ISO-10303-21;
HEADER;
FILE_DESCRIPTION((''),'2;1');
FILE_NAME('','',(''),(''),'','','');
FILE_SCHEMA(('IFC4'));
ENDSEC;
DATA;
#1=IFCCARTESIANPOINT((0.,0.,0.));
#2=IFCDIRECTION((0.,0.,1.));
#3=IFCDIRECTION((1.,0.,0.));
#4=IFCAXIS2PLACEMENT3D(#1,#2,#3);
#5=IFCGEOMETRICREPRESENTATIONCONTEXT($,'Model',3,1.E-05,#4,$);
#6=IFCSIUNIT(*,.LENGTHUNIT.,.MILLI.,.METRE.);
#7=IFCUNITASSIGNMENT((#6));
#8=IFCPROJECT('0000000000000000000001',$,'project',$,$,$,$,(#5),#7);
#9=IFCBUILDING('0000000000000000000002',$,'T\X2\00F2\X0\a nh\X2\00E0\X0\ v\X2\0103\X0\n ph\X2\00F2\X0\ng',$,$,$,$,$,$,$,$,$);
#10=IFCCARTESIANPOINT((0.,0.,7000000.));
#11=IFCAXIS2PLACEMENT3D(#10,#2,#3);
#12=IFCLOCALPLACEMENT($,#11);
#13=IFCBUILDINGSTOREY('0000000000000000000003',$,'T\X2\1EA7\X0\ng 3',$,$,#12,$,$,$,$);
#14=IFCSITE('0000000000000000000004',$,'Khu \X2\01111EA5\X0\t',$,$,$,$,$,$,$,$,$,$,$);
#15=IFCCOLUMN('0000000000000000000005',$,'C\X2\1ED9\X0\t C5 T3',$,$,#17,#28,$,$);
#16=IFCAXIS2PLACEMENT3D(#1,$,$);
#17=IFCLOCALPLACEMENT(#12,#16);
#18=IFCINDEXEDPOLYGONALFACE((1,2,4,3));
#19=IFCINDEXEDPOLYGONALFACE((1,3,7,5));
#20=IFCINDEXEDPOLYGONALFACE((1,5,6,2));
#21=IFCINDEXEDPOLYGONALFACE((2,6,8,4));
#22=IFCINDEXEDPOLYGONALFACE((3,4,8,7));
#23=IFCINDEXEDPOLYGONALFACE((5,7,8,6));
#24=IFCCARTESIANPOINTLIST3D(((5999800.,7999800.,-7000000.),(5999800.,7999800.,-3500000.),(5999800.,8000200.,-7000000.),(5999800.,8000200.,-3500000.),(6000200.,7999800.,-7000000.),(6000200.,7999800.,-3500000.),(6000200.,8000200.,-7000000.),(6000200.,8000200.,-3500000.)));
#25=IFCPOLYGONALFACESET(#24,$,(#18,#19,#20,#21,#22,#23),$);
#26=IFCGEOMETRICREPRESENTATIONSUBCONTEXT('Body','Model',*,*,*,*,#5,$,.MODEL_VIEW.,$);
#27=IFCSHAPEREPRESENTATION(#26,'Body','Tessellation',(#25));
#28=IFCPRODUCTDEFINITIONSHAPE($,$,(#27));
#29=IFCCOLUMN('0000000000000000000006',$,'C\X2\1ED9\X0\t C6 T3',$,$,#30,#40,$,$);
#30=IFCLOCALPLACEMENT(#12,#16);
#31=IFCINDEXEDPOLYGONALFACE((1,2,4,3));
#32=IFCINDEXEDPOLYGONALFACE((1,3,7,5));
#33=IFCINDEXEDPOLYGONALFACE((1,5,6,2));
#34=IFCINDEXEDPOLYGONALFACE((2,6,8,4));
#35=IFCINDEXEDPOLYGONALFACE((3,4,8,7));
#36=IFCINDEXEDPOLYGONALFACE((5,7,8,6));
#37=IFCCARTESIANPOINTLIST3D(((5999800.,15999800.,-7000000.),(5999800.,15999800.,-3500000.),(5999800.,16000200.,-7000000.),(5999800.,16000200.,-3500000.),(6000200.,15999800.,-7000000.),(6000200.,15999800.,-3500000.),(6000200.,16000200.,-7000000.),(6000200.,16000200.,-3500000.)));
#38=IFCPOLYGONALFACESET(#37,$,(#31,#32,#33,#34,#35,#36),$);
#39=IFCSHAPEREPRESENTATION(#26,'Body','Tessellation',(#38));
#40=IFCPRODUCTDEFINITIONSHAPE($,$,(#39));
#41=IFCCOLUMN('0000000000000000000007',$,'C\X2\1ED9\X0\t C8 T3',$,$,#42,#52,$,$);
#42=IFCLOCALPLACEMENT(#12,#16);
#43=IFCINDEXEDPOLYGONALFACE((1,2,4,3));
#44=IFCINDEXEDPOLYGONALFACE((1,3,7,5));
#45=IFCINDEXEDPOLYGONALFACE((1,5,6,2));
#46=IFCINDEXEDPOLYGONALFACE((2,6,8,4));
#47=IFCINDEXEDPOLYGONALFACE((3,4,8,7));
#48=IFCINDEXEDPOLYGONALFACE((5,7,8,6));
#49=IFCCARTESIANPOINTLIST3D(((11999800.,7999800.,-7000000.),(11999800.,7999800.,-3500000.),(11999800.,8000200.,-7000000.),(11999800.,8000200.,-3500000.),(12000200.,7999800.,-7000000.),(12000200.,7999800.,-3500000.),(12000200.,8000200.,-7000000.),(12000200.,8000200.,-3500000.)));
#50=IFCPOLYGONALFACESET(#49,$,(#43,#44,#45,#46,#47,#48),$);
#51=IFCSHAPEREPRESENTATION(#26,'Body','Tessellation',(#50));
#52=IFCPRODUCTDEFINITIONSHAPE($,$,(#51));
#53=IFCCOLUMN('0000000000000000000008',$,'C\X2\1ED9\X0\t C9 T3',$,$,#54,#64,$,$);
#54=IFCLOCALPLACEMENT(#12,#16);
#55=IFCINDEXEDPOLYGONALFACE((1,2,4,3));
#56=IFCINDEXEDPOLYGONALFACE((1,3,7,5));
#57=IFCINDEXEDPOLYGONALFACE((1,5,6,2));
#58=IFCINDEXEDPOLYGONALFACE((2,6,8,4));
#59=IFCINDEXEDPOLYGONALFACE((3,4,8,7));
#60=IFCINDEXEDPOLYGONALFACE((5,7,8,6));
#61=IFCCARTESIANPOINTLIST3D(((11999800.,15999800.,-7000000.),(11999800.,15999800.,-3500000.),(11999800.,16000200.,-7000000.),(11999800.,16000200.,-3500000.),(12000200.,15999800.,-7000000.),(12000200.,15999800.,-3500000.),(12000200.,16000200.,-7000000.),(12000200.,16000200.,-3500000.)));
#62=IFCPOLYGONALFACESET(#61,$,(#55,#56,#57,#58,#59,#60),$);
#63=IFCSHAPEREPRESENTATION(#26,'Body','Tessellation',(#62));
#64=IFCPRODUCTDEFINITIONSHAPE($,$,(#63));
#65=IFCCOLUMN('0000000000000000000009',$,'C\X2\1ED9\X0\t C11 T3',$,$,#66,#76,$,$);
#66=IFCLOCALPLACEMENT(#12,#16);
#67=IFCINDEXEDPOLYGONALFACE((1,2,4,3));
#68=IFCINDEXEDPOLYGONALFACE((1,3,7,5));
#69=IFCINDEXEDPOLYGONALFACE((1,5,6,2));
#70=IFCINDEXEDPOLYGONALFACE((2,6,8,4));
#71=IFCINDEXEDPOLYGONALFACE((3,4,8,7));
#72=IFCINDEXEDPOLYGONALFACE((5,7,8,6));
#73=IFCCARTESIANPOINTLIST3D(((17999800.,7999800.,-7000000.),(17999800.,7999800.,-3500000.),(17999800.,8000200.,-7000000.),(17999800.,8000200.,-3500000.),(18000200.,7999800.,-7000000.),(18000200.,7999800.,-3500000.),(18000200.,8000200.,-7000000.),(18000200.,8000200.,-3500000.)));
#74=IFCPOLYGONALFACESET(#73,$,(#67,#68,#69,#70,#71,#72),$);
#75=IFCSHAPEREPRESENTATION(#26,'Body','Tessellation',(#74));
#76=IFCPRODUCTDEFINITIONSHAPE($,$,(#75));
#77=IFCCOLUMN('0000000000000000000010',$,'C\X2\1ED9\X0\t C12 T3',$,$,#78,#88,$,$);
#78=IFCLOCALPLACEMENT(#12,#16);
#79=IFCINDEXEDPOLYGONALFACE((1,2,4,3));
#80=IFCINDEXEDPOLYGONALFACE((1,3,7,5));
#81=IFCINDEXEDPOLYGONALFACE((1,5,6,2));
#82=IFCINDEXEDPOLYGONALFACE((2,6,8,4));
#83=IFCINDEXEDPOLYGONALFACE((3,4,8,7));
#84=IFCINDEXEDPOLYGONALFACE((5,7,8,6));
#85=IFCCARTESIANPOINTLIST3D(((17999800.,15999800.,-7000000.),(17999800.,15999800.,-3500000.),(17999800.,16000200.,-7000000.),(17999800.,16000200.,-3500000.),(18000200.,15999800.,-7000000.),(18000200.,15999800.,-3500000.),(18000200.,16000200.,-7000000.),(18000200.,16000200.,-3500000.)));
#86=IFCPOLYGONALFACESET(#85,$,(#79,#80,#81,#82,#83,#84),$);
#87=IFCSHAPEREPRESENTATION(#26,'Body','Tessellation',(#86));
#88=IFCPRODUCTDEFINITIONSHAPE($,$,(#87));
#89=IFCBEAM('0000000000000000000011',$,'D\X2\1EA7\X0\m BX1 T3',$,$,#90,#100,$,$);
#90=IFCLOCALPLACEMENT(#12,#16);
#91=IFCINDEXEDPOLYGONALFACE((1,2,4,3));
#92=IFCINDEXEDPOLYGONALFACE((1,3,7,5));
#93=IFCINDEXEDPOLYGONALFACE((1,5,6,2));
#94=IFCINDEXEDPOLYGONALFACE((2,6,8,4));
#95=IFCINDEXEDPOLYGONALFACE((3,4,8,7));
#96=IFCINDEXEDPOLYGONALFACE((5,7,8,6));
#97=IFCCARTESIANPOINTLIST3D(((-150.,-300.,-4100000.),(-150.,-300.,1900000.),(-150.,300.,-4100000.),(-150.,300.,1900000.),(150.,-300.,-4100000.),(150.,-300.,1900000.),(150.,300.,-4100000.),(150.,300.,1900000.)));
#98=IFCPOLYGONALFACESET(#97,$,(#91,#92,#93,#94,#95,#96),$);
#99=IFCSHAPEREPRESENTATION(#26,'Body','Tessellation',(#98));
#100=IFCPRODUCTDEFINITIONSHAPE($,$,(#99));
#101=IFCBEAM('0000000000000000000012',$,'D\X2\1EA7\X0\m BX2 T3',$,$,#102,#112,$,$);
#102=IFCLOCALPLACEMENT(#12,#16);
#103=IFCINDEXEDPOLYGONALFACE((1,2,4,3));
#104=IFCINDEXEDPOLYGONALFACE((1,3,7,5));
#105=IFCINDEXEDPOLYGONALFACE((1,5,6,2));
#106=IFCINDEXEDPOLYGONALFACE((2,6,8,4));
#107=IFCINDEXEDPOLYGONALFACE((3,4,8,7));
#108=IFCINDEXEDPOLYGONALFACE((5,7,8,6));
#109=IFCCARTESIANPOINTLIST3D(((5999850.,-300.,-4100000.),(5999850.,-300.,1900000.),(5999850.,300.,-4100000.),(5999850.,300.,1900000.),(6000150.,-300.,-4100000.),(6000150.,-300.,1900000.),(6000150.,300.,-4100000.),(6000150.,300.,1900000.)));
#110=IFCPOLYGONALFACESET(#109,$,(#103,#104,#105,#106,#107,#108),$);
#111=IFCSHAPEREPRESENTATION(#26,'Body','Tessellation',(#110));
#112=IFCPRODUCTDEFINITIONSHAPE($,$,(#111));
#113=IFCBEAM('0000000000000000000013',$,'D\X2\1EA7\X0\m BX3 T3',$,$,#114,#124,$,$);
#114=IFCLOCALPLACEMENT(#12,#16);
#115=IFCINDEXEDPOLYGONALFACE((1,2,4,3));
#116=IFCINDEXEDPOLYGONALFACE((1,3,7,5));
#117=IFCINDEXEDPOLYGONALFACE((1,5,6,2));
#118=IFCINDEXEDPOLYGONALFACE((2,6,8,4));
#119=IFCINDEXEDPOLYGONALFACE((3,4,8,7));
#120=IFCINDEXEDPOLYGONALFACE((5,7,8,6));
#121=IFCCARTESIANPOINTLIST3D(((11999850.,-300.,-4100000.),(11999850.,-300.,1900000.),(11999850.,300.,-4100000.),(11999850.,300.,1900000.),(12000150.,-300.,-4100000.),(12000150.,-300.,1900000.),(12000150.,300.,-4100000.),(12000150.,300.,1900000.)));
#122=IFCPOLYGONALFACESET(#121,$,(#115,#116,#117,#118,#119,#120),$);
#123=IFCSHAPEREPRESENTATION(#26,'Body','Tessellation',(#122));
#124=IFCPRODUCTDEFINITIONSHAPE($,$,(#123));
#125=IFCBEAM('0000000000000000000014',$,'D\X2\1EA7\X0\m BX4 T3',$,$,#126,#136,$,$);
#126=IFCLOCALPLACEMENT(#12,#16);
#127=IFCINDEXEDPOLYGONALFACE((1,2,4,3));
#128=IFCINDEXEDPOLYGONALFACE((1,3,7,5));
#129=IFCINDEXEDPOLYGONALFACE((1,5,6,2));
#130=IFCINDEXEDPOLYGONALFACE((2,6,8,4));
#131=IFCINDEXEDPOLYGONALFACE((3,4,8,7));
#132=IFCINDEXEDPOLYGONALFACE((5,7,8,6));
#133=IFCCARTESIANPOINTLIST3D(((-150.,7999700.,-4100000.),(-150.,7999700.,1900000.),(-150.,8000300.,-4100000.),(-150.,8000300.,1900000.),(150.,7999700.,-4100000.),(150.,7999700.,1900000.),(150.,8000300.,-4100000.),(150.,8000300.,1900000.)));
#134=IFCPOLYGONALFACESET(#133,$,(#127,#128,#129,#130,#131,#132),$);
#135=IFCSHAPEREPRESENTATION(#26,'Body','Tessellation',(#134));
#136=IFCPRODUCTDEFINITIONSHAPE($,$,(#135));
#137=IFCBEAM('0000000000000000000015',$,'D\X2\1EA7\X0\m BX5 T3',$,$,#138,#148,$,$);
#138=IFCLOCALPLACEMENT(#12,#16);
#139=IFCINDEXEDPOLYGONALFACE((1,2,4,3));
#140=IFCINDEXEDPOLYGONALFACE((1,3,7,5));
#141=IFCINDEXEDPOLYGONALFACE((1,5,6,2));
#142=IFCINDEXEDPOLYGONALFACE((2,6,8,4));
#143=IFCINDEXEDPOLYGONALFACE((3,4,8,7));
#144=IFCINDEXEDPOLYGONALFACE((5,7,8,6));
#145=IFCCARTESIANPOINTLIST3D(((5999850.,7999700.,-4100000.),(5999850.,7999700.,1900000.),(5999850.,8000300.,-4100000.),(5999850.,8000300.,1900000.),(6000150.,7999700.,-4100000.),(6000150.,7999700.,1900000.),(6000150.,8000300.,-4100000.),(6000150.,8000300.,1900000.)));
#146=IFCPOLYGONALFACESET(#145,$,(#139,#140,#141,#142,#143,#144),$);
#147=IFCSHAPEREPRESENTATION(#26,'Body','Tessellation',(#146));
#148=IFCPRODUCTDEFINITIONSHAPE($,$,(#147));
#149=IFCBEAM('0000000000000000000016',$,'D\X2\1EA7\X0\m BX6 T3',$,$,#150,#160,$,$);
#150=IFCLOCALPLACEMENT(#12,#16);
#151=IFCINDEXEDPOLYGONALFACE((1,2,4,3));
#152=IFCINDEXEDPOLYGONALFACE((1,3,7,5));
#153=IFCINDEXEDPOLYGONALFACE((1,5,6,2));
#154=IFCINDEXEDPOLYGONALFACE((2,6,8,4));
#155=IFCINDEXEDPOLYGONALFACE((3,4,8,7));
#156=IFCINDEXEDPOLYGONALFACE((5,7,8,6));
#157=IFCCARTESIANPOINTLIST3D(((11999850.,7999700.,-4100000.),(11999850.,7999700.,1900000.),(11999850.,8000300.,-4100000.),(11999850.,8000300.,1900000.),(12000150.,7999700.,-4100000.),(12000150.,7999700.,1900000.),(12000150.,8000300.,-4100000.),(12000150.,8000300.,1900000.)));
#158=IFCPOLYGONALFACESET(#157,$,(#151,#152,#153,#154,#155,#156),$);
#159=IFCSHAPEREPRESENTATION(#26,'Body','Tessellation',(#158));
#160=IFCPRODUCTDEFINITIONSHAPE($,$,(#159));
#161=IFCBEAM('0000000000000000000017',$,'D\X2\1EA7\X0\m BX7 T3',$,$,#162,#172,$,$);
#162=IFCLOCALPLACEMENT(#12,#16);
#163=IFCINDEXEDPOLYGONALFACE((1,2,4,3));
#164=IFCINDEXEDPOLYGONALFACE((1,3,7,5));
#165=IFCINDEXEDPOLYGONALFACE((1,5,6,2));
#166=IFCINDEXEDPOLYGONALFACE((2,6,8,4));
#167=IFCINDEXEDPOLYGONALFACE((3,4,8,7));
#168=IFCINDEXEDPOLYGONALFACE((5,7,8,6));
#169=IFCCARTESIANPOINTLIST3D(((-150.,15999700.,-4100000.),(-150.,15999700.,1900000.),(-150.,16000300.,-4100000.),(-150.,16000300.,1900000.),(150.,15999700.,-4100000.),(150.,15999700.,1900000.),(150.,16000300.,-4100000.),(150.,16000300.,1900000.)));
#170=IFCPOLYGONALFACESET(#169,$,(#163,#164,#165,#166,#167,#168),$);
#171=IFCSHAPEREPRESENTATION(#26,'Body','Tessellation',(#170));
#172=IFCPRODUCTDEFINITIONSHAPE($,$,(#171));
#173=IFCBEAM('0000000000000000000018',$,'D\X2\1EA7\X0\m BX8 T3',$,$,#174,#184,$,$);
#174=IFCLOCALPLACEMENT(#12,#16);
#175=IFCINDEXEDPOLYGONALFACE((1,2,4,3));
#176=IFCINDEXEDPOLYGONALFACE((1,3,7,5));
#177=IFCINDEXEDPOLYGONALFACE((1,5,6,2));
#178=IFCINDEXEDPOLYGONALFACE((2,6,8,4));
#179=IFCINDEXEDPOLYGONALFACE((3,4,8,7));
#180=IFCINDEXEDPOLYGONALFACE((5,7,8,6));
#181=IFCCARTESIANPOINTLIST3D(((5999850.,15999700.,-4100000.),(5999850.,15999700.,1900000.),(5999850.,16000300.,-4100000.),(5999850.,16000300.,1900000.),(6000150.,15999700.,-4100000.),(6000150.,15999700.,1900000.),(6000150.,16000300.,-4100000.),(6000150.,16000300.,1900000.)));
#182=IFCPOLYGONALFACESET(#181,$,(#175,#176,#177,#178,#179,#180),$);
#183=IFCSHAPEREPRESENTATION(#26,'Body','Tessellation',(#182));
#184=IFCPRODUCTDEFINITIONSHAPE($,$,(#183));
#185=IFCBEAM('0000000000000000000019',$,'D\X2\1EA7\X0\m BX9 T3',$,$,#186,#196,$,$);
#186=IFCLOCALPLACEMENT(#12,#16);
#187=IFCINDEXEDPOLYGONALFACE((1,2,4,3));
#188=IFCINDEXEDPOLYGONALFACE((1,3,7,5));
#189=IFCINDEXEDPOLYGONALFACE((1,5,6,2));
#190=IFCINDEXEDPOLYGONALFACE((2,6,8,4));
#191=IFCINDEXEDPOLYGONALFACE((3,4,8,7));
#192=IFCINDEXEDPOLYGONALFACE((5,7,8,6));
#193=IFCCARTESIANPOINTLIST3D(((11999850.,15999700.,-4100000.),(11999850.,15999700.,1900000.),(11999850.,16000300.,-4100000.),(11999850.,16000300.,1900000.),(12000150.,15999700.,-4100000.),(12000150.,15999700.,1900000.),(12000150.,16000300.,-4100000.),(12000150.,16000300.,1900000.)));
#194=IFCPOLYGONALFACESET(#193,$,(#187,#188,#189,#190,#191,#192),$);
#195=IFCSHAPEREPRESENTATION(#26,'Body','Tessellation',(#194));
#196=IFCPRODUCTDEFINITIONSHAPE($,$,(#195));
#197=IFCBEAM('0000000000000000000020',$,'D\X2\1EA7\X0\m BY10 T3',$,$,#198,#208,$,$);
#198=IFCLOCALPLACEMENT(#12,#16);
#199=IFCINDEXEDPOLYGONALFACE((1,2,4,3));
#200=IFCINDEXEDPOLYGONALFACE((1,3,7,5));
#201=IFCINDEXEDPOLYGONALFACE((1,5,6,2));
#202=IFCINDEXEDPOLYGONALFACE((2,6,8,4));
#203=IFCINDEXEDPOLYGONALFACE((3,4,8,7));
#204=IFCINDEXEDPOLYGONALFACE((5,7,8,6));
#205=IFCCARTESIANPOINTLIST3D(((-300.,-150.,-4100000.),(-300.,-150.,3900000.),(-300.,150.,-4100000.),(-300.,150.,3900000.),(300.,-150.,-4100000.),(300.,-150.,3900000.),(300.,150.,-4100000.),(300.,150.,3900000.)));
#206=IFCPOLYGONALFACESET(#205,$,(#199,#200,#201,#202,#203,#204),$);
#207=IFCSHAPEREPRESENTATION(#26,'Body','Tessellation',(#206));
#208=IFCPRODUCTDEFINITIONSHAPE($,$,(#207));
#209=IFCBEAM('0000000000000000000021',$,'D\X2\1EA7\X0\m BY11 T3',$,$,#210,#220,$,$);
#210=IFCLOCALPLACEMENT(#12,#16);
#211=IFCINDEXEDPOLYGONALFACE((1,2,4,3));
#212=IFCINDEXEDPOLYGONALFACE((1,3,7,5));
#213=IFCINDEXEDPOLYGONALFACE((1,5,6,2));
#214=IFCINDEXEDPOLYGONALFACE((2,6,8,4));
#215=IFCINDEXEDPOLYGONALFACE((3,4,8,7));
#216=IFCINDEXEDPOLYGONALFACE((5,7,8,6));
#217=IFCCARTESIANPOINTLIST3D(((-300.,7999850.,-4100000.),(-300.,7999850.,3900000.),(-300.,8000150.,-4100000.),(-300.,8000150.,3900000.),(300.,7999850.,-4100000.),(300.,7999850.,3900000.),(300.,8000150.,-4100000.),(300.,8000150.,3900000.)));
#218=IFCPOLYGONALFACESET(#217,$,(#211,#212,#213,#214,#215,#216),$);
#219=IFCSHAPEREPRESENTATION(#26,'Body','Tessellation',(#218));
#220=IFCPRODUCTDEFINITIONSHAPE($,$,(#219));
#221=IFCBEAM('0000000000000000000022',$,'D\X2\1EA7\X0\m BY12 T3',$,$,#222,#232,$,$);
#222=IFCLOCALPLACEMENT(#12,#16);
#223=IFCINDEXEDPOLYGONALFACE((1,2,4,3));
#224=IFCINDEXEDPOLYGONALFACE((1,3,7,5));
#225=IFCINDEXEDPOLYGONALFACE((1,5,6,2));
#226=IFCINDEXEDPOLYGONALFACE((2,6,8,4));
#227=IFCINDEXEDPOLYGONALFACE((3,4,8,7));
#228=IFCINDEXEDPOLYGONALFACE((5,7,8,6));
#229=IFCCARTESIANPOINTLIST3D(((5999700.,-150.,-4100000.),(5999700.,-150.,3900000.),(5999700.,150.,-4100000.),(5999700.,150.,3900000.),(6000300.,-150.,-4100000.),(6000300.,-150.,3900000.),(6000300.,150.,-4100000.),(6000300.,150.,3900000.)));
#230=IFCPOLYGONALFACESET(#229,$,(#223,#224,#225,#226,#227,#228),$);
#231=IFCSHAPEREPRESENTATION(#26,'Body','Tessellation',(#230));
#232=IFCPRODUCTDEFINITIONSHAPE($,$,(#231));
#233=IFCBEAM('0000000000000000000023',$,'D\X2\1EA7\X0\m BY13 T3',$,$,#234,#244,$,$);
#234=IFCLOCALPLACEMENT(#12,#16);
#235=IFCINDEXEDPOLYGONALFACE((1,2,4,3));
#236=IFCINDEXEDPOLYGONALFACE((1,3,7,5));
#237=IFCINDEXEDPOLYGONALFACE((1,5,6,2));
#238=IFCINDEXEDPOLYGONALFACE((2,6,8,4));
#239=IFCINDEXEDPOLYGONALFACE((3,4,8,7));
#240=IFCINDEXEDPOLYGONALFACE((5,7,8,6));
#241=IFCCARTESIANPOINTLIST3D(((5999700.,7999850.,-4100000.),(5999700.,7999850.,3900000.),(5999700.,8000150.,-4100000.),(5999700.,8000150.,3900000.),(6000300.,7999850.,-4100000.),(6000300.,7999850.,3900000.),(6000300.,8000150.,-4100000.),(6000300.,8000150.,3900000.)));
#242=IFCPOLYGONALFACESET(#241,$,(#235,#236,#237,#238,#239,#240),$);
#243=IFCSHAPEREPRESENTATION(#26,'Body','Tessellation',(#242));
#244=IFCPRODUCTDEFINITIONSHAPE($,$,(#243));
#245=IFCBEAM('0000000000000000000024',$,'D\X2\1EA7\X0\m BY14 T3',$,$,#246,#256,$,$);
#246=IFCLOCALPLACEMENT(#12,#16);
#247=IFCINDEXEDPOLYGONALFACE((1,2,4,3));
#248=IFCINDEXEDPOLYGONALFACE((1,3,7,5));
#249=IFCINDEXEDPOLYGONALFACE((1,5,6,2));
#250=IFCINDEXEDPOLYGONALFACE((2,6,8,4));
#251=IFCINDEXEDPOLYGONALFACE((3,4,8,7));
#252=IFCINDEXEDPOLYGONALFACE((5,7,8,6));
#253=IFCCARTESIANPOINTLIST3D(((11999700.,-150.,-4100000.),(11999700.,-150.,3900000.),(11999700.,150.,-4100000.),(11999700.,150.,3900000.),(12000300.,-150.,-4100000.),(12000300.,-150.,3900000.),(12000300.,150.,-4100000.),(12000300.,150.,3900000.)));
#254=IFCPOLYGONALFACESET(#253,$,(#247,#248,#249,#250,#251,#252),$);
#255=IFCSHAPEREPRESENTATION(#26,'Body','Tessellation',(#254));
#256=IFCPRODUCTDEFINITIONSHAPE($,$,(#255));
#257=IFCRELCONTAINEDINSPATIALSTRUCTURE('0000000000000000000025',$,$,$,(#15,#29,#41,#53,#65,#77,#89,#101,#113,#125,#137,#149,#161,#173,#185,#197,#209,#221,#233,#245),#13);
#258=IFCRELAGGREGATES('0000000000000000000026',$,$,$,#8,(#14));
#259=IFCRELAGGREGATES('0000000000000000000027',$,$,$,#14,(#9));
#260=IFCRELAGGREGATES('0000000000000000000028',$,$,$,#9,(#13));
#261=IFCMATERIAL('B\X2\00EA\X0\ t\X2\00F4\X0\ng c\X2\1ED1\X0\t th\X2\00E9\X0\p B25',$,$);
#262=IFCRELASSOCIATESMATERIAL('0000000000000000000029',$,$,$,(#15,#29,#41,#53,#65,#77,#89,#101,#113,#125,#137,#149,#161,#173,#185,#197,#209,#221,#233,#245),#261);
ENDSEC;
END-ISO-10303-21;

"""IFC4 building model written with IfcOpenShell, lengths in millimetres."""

from ifc_helpers import new_model, entity, si_unit, frame, origin_with_axes, place, context, subcontext, project, spatial, extrude, material, element, save


model = new_model("IFC4")

# Units and contexts
model_context = context("Model", 3, precision=1e-05, world=origin_with_axes())
body_context = subcontext(model_context, "Body", "Model", "MODEL_VIEW")
ifc_project = project(units=[si_unit("LENGTHUNIT", "METRE", prefix="MILLI")], contexts=[model_context])

# Site, building, storey
site = spatial("IfcSite", under=ifc_project, Name="Khu đất")
building = spatial("IfcBuilding", under=site, Name="Tòa nhà văn phòng")
storey_placement = place(None, frame((0.0, 0.0, 7000000.0), z_axis=(0.0, 0.0, 1.0), x_axis=(1.0, 0.0, 0.0)))
storey = spatial("IfcBuildingStorey", under=building, at=storey_placement, Name="Tầng 3")

# Columns
ifc_material_1 = material(Name="Bê tông cốt thép B25")
for number, where, z_axis, x_axis, name in (
    (1, (6000000.0, 8000000.0, -7000000.0), (0.0, 0.0, 1.0), (1.0, 0.0, 0.0), "Cột C5 T3"),
    (2, (6000000.0, 16000000.0, -7000000.0), (0.0, 0.0, 1.0), (1.0, 0.0, 0.0), "Cột C6 T3"),
    (3, (12000000.0, 8000000.0, -7000000.0), (0.0, 0.0, 1.0), (1.0, 0.0, 0.0), "Cột C8 T3"),
    (4, (12000000.0, 16000000.0, -7000000.0), (0.0, 0.0, 1.0), (1.0, 0.0, 0.0), "Cột C9 T3"),
    (5, (18000000.0, 8000000.0, -7000000.0), (0.0, 0.0, 1.0), (1.0, 0.0, 0.0), "Cột C11 T3"),
    (6, (18000000.0, 16000000.0, -7000000.0), (0.0, 0.0, 1.0), (1.0, 0.0, 0.0), "Cột C12 T3"),
):
    element("IfcColumn", number, at=place(storey_placement, frame(where, z_axis=z_axis, x_axis=x_axis)), inside=storey, material=ifc_material_1, Name=name, context=body_context, shape_type="SweptSolid", body=[
        extrude(entity("IfcRectangleProfileDef", None, None, None, 400.0, 400.0), origin_with_axes(), (0.0, 0.0, 1.0), 3500000.0),
    ])

# Beams
for number, where, z_axis, x_axis, name in (
    (7, (0.0, 0.0, -4100000.0), (0.0, 0.0, 1.0), (1.0, 0.0, 0.0), "Dầm BX1 T3"),
    (8, (6000000.0, 0.0, -4100000.0), (0.0, 0.0, 1.0), (1.0, 0.0, 0.0), "Dầm BX2 T3"),
    (9, (12000000.0, 0.0, -4100000.0), (0.0, 0.0, 1.0), (1.0, 0.0, 0.0), "Dầm BX3 T3"),
    (10, (0.0, 8000000.0, -4100000.0), (0.0, 0.0, 1.0), (1.0, 0.0, 0.0), "Dầm BX4 T3"),
    (11, (6000000.0, 8000000.0, -4100000.0), (0.0, 0.0, 1.0), (1.0, 0.0, 0.0), "Dầm BX5 T3"),
    (12, (12000000.0, 8000000.0, -4100000.0), (0.0, 0.0, 1.0), (1.0, 0.0, 0.0), "Dầm BX6 T3"),
    (13, (0.0, 16000000.0, -4100000.0), (0.0, 0.0, 1.0), (1.0, 0.0, 0.0), "Dầm BX7 T3"),
    (14, (6000000.0, 16000000.0, -4100000.0), (0.0, 0.0, 1.0), (1.0, 0.0, 0.0), "Dầm BX8 T3"),
    (15, (12000000.0, 16000000.0, -4100000.0), (0.0, 0.0, 1.0), (1.0, 0.0, 0.0), "Dầm BX9 T3"),
):
    element("IfcBeam", number, at=place(storey_placement, frame(where, z_axis=z_axis, x_axis=x_axis)), inside=storey, material=ifc_material_1, Name=name, context=body_context, shape_type="SweptSolid", body=[
        extrude(entity("IfcRectangleProfileDef", None, None, None, 300.0, 600.0), origin_with_axes(), (0.0, 0.0, 1.0), 6000000.0),
    ])
for number, where, z_axis, x_axis, name in (
    (16, (0.0, 0.0, -4100000.0), (0.0, 0.0, 1.0), (0.0, 1.0, 0.0), "Dầm BY10 T3"),
    (17, (0.0, 8000000.0, -4100000.0), (0.0, 0.0, 1.0), (0.0, 1.0, 0.0), "Dầm BY11 T3"),
    (18, (6000000.0, 0.0, -4100000.0), (0.0, 0.0, 1.0), (0.0, 1.0, 0.0), "Dầm BY12 T3"),
    (19, (6000000.0, 8000000.0, -4100000.0), (0.0, 0.0, 1.0), (0.0, 1.0, 0.0), "Dầm BY13 T3"),
    (20, (12000000.0, 0.0, -4100000.0), (0.0, 0.0, 1.0), (0.0, 1.0, 0.0), "Dầm BY14 T3"),
):
    element("IfcBeam", number, at=place(storey_placement, frame(where, z_axis=z_axis, x_axis=x_axis)), inside=storey, material=ifc_material_1, Name=name, context=body_context, shape_type="SweptSolid", body=[
        extrude(entity("IfcRectangleProfileDef", None, None, None, 300.0, 600.0), origin_with_axes(), (0.0, 0.0, 1.0), 8000000.0),
    ])

save(model, "model.ifc")
